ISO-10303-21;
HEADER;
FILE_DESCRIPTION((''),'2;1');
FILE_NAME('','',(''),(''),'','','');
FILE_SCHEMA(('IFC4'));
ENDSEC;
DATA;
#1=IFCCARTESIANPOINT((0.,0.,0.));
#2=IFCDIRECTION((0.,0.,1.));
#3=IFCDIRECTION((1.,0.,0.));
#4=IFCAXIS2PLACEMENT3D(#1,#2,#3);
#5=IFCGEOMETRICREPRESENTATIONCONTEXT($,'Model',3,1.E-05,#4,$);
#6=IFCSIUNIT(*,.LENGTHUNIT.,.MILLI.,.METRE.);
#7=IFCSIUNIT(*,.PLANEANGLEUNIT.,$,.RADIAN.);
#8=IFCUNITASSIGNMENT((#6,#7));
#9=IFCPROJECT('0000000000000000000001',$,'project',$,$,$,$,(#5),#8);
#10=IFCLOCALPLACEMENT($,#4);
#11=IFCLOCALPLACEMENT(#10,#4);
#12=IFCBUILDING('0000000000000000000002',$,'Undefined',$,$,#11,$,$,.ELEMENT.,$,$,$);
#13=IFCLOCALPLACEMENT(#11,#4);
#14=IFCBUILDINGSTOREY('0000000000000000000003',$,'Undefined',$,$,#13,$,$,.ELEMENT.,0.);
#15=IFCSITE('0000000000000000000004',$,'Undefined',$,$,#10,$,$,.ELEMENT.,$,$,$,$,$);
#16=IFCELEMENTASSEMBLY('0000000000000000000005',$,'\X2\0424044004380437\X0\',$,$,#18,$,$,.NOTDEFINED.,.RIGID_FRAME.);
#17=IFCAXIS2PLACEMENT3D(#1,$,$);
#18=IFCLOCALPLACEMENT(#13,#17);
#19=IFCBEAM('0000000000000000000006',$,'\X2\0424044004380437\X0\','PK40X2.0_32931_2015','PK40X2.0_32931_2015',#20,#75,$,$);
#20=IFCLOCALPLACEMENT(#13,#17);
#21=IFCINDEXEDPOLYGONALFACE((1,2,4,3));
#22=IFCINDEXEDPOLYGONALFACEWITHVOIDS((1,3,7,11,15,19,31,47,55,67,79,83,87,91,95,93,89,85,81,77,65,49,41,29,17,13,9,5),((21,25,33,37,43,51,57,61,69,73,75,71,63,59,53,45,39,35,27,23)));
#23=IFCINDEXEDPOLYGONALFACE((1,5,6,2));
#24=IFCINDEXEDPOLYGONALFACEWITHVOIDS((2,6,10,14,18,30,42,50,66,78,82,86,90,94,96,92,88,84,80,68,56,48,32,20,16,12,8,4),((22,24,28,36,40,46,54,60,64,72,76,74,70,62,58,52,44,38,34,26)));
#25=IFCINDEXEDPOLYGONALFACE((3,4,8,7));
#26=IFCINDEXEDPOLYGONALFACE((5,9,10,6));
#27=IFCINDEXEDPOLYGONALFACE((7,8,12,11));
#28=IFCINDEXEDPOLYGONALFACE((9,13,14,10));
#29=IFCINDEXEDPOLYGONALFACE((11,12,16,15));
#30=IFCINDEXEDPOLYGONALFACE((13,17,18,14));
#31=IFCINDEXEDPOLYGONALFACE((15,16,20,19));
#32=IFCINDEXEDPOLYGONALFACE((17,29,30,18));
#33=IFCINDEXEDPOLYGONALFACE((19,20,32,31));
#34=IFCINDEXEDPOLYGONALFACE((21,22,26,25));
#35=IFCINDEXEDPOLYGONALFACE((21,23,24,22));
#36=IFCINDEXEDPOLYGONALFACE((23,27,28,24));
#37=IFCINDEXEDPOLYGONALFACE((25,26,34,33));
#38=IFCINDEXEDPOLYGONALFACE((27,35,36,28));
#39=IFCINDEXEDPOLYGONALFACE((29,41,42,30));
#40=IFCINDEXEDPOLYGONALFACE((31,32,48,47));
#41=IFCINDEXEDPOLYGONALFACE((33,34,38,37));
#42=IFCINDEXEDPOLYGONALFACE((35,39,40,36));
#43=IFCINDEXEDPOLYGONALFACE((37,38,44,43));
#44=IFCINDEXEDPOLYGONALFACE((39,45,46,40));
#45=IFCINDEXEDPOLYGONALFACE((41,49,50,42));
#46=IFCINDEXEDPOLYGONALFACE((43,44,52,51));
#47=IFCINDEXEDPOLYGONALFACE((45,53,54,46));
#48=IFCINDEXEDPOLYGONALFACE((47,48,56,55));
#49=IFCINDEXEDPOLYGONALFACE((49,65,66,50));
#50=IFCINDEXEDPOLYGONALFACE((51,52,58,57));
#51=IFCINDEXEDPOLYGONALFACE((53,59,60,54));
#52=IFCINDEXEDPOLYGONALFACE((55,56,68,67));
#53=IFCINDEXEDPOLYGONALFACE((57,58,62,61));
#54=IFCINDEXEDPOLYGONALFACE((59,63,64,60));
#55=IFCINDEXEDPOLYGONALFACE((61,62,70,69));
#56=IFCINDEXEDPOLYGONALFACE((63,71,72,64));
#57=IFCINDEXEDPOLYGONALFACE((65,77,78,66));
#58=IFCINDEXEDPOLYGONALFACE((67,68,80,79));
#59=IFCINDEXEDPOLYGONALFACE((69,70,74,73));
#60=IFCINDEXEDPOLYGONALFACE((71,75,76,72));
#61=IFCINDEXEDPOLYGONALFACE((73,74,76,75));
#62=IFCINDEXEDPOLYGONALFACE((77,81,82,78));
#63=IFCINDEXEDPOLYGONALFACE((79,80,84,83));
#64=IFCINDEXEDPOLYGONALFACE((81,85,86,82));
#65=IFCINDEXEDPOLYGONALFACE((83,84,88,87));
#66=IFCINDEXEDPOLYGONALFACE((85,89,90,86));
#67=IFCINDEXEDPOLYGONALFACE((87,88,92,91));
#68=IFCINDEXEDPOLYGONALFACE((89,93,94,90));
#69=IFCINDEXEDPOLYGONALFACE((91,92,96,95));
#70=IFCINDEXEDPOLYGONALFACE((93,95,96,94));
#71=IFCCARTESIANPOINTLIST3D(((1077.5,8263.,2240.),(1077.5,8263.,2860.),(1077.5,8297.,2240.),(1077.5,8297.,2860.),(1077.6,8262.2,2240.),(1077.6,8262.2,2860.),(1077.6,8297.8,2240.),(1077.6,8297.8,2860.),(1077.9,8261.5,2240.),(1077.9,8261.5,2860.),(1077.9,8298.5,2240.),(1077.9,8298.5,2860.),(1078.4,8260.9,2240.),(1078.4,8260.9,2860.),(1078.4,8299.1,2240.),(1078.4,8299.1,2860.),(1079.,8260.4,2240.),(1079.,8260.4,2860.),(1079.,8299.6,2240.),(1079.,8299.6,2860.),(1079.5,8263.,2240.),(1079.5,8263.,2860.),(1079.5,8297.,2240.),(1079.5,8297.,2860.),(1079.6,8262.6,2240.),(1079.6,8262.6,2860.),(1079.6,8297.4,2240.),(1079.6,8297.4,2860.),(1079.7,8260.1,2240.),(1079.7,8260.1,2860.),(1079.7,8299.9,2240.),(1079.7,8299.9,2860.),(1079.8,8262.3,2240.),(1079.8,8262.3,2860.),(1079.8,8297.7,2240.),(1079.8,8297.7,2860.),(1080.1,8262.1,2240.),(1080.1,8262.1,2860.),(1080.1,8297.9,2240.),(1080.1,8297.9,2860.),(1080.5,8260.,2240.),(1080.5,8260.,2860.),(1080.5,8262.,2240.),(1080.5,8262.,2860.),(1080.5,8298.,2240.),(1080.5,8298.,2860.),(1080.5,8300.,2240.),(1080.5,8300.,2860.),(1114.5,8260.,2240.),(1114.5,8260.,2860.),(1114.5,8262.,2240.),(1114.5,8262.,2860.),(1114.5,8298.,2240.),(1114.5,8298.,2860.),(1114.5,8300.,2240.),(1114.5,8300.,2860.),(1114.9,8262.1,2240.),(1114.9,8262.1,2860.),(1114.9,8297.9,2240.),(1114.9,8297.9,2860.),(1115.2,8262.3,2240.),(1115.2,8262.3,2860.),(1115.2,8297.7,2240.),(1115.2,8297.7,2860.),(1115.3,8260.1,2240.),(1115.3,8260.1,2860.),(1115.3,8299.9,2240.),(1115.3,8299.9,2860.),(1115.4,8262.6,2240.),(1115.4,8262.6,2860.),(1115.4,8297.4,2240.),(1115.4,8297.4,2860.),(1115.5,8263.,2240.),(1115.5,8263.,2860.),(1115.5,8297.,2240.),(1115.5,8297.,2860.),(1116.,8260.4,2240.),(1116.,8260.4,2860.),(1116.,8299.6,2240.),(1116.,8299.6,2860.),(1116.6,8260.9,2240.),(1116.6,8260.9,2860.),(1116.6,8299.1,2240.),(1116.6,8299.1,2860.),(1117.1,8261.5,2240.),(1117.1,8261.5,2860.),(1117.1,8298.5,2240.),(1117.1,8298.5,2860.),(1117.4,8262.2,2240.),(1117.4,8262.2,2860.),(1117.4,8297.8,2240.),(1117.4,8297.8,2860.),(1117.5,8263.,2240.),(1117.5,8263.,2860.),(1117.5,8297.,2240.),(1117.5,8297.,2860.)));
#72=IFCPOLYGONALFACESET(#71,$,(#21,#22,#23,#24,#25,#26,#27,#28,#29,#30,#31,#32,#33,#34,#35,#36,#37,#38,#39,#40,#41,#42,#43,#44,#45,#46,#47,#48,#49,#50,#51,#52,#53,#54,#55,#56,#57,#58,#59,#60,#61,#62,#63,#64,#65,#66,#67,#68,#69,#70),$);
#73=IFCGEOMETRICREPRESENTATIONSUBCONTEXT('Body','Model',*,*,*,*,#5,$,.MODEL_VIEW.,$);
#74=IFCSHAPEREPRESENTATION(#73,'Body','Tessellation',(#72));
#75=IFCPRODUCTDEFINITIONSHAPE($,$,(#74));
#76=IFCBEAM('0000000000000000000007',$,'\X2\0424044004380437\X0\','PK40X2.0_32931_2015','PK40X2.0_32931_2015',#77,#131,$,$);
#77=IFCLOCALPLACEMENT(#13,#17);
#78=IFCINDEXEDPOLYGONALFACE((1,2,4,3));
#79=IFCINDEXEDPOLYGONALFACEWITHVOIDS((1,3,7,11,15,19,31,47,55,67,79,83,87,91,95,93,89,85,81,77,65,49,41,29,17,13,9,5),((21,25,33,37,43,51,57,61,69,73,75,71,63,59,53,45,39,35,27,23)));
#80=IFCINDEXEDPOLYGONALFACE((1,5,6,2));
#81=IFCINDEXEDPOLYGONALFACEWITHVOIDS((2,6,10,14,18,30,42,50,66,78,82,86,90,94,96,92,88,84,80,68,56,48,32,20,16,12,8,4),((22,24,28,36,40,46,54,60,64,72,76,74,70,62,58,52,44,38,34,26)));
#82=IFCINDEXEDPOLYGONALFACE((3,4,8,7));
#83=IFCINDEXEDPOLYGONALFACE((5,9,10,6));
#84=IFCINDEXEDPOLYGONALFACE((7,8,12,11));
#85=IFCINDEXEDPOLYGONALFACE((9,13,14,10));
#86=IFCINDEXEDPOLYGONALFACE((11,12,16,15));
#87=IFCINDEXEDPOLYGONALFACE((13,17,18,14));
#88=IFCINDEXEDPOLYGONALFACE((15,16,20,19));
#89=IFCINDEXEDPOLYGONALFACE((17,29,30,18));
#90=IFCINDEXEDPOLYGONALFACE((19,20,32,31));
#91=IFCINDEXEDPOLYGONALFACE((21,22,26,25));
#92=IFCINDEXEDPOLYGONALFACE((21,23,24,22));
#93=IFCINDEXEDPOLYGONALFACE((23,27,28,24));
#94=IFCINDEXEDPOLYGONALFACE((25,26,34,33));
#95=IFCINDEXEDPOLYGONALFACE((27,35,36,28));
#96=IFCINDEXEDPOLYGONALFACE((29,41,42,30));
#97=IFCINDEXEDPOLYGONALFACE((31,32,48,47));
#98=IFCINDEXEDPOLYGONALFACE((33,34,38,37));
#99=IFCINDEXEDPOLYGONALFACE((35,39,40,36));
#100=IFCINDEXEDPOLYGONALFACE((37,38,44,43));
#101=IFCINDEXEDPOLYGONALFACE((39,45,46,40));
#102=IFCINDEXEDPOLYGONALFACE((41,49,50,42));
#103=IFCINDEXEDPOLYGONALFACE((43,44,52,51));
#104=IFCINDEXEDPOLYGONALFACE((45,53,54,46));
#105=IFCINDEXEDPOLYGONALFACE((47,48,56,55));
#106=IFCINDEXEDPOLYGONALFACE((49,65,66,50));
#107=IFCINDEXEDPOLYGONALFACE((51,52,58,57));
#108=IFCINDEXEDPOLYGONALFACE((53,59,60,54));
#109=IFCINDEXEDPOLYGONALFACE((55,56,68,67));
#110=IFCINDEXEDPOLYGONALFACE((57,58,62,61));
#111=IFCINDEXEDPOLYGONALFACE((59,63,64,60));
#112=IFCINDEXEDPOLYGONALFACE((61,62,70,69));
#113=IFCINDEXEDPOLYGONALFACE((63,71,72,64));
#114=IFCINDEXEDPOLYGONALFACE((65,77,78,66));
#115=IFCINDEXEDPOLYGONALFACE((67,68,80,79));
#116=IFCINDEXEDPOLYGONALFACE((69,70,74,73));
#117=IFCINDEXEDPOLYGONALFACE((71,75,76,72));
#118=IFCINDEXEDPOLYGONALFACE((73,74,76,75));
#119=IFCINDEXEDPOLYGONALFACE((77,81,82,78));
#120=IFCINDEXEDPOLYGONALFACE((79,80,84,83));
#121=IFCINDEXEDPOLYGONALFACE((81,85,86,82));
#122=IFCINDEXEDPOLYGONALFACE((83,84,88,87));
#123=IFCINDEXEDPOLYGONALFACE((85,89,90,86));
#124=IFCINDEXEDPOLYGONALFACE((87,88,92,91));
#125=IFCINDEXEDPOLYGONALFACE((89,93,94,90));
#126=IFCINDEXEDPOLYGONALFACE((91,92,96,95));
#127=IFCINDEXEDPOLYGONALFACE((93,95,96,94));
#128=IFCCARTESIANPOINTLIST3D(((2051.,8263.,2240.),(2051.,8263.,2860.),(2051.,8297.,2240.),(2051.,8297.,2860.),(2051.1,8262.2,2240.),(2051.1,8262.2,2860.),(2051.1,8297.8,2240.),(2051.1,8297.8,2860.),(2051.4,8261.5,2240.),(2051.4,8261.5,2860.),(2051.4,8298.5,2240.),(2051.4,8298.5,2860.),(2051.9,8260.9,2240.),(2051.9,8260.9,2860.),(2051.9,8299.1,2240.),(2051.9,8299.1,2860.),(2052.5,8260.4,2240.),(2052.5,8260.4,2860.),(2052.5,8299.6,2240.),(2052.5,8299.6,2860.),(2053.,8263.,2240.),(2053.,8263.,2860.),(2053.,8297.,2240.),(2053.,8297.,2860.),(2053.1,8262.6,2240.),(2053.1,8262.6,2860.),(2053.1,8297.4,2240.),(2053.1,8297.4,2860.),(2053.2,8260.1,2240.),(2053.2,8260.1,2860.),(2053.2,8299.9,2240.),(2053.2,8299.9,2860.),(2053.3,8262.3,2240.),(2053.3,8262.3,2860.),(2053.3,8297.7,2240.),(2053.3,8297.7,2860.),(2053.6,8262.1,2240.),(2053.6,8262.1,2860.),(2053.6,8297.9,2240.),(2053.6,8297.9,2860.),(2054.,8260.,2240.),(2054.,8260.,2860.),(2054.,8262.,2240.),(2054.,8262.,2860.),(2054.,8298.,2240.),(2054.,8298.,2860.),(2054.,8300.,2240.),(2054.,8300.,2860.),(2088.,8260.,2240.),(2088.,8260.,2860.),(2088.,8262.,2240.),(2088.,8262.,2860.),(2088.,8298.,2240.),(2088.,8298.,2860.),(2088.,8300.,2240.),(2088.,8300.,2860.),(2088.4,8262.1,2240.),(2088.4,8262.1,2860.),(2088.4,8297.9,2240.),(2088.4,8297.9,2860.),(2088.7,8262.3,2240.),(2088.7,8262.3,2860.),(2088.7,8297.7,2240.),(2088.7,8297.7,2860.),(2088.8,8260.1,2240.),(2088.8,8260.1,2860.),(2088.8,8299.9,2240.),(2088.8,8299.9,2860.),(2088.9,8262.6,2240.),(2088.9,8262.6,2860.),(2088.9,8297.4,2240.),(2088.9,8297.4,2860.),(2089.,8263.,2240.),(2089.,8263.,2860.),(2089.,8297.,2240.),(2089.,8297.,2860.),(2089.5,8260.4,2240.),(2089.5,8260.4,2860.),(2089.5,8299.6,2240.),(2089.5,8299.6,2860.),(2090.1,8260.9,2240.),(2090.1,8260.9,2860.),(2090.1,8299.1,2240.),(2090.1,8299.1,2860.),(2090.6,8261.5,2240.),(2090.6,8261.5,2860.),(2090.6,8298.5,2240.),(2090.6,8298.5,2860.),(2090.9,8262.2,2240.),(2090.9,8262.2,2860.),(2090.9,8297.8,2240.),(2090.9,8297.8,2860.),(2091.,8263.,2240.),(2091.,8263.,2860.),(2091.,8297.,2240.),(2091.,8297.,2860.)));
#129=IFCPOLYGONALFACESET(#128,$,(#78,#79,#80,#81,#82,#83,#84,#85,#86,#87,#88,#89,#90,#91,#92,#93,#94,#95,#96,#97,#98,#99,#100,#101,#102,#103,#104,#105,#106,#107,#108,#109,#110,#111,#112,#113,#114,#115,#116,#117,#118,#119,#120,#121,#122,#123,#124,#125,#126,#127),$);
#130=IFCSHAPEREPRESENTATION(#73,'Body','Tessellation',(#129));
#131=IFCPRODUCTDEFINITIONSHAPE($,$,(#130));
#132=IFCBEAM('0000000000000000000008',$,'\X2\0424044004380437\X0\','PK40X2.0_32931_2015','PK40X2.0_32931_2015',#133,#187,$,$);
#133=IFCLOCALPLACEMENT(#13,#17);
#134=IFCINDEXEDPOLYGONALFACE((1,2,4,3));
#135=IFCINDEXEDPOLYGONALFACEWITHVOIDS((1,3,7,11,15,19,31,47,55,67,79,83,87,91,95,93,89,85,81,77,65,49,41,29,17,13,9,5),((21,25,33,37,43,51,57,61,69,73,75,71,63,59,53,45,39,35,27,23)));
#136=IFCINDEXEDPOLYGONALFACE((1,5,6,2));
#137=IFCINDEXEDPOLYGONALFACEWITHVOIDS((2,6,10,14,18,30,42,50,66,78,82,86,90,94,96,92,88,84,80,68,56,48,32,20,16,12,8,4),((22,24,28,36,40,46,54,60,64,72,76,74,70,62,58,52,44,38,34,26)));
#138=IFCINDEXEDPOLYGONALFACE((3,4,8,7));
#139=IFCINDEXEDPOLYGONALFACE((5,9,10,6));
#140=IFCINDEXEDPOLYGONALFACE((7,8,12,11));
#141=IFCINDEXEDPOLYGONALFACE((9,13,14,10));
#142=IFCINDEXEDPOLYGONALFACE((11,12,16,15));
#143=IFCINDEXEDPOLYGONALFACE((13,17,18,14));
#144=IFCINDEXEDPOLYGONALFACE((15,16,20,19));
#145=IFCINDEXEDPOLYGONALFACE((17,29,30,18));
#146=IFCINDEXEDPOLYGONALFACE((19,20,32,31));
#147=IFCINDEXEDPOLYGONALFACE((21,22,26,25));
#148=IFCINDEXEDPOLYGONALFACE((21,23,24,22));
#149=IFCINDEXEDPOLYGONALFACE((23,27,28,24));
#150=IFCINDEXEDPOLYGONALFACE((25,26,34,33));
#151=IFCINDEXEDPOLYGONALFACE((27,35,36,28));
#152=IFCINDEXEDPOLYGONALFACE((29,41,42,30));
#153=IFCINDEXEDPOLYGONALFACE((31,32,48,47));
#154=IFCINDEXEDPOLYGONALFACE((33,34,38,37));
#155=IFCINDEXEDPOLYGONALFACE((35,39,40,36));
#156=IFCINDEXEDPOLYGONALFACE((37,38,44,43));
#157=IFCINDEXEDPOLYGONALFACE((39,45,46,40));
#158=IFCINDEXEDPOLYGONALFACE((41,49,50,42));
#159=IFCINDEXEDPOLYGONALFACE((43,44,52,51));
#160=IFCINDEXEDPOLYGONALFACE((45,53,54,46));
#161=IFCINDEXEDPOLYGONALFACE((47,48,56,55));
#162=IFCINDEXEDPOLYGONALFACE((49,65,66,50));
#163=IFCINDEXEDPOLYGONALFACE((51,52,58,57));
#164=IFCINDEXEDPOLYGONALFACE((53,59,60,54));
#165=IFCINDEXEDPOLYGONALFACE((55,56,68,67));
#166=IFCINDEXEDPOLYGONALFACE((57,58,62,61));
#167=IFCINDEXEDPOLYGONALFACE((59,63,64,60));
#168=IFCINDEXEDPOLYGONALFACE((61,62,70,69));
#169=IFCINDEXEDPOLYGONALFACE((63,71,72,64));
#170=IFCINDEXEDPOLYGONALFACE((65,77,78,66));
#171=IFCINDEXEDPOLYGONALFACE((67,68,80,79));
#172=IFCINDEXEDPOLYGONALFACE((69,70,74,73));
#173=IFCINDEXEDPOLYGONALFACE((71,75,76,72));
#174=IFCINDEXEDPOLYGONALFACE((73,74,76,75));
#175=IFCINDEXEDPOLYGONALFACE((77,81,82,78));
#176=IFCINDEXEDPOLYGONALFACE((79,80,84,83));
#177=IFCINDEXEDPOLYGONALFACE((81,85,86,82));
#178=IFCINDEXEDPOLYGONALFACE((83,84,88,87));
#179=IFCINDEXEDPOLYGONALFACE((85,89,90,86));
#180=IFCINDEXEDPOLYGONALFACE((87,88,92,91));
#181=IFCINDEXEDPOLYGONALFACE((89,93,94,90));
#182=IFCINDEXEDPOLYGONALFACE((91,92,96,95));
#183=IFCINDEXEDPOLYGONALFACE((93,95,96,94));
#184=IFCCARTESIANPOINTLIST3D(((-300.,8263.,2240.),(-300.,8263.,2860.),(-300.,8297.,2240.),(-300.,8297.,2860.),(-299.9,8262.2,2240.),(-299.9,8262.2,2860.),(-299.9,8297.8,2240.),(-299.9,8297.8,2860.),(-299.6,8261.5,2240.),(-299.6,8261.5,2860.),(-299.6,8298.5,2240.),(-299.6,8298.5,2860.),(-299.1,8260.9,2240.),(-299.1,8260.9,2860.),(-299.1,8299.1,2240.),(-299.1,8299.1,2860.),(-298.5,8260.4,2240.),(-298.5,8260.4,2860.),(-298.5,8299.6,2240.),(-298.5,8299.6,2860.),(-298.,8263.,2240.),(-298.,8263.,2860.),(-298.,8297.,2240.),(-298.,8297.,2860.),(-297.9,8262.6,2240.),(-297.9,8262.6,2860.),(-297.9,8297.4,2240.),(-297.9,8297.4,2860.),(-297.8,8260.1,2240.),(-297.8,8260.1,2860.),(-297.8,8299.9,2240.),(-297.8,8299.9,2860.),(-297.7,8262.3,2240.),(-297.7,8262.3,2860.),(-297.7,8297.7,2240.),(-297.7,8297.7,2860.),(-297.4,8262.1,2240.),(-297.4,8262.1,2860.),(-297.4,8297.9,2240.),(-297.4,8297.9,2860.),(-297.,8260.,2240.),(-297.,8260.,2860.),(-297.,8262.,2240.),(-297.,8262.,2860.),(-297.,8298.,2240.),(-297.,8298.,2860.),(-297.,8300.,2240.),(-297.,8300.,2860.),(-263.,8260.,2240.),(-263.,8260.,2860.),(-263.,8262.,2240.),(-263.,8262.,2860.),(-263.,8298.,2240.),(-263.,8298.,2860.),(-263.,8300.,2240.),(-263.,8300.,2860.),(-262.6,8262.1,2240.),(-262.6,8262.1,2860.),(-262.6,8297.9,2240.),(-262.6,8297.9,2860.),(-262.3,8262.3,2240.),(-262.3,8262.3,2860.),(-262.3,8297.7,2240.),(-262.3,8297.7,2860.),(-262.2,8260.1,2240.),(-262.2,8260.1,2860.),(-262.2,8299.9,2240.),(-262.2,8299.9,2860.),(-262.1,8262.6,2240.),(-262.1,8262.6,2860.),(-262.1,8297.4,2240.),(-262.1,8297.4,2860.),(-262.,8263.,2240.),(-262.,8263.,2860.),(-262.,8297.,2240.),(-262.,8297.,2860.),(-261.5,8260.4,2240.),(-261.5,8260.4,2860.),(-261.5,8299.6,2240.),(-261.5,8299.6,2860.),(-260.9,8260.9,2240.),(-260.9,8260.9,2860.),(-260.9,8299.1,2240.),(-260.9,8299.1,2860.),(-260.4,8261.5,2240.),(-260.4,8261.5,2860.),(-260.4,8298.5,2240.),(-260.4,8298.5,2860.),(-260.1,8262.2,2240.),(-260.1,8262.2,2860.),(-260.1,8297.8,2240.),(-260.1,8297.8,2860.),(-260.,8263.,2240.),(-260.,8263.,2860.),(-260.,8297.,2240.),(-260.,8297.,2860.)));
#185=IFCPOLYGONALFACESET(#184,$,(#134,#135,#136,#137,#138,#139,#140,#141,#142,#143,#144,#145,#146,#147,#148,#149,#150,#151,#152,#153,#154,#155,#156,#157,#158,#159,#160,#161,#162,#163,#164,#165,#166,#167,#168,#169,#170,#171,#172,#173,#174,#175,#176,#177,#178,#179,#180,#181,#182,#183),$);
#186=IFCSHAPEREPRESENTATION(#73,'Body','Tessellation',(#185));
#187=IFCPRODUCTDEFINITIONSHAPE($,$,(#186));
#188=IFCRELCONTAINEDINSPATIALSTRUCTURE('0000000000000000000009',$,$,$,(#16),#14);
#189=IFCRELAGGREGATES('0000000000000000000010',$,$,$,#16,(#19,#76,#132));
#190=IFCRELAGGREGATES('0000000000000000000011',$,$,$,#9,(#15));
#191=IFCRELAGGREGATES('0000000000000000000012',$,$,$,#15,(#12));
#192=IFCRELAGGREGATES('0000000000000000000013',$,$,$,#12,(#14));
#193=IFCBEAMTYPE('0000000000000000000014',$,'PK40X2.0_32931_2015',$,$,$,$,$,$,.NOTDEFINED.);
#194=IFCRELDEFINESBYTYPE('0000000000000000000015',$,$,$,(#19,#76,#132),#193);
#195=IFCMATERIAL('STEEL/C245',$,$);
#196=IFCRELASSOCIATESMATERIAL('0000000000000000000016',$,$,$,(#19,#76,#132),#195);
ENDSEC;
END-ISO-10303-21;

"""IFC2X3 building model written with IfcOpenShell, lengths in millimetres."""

from ifc_helpers import new_model, si_unit, frame, origin_with_axes, origin_2d_with_axis, place, context, subcontext, project, spatial, hollow_rectangle, extrude, material, type_object, element, aggregate, save


model = new_model("IFC2X3")

# Units and contexts
model_context = context("Model", 3, precision=1e-05, world=origin_with_axes())
body_context = subcontext(model_context, "Body", "Model", "MODEL_VIEW")
ifc_project = project(units=[si_unit("LENGTHUNIT", "METRE", prefix="MILLI"), si_unit("PLANEANGLEUNIT", "RADIAN")], contexts=[model_context])

# Site, building, storey
site_placement = place(None, origin_with_axes())
site = spatial("IfcSite", under=ifc_project, at=site_placement, Name="Undefined", CompositionType="ELEMENT")
building_placement = place(site_placement, origin_with_axes())
building = spatial("IfcBuilding", under=site, at=building_placement, Name="Undefined", CompositionType="ELEMENT")
storey_placement = place(building_placement, origin_with_axes())
storey = spatial("IfcBuildingStorey", under=building, at=storey_placement, Name="Undefined", CompositionType="ELEMENT", Elevation=0.0)

# Shared definitions
ifc_material_1 = material(Name="STEEL/C245")

# Shared definitions
beam_type_1 = type_object("IfcBeamType", Name="PK40X2.0_32931_2015", PredefinedType="NOTDEFINED")

# Element assembly, beams
assembly_1_placement = place(storey_placement, origin_with_axes())
assembly_1 = element("IfcElementAssembly", 1, at=assembly_1_placement, inside=storey, Name="Фриз", AssemblyPlace="NOTDEFINED", PredefinedType="RIGID_FRAME")
beam_1_placement = place(assembly_1_placement, frame((1097.5, 8280.0, 2860.0), z_axis=(1.0, 0.0, 0.0), x_axis=(0.0, 0.0, -1.0)))
beam_1 = element("IfcBeam", 2, at=beam_1_placement, type_object=beam_type_1, material=ifc_material_1, Name="Фриз", Description="PK40X2.0_32931_2015", ObjectType="PK40X2.0_32931_2015", context=body_context, shape_type="SweptSolid", body=[
    extrude(hollow_rectangle(XDim=40.0, YDim=40.0, WallThickness=2.0, InnerFilletRadius=1.0, OuterFilletRadius=3.0, at=origin_2d_with_axis()), frame((620.0, 0.0, 0.0), z_axis=(-1.0, 0.0, 0.0), x_axis=(0.0, -1.0, 0.0)), (0.0, 0.0, 1.0), 620.0),
])
beam_2_placement = place(assembly_1_placement, frame((2071.0, 8280.0, 2860.0), z_axis=(1.0, 0.0, 0.0), x_axis=(0.0, 0.0, -1.0)))
beam_2 = element("IfcBeam", 3, at=beam_2_placement, type_object=beam_type_1, material=ifc_material_1, Name="Фриз", Description="PK40X2.0_32931_2015", ObjectType="PK40X2.0_32931_2015", context=body_context, shape_type="SweptSolid", body=[
    extrude(hollow_rectangle(XDim=40.0, YDim=40.0, WallThickness=2.0, InnerFilletRadius=1.0, OuterFilletRadius=3.0, at=origin_2d_with_axis()), frame((620.0, 0.0, 0.0), z_axis=(-1.0, 0.0, 0.0), x_axis=(0.0, -1.0, 0.0)), (0.0, 0.0, 1.0), 620.0),
])
beam_3_placement = place(assembly_1_placement, frame((-280.0, 8280.0, 2860.0), z_axis=(-1.0, 0.0, 0.0), x_axis=(0.0, 0.0, -1.0)))
beam_3 = element("IfcBeam", 4, at=beam_3_placement, type_object=beam_type_1, material=ifc_material_1, Name="Фриз", Description="PK40X2.0_32931_2015", ObjectType="PK40X2.0_32931_2015", context=body_context, shape_type="SweptSolid", body=[
    extrude(hollow_rectangle(XDim=40.0, YDim=40.0, WallThickness=2.0, InnerFilletRadius=1.0, OuterFilletRadius=3.0, at=origin_2d_with_axis()), frame((620.0, 0.0, 0.0), z_axis=(-1.0, 0.0, 0.0), x_axis=(0.0, -1.0, 0.0)), (0.0, 0.0, 1.0), 620.0),
])
aggregate(assembly_1, [beam_1, beam_2, beam_3])

save(model, "model.ifc")
